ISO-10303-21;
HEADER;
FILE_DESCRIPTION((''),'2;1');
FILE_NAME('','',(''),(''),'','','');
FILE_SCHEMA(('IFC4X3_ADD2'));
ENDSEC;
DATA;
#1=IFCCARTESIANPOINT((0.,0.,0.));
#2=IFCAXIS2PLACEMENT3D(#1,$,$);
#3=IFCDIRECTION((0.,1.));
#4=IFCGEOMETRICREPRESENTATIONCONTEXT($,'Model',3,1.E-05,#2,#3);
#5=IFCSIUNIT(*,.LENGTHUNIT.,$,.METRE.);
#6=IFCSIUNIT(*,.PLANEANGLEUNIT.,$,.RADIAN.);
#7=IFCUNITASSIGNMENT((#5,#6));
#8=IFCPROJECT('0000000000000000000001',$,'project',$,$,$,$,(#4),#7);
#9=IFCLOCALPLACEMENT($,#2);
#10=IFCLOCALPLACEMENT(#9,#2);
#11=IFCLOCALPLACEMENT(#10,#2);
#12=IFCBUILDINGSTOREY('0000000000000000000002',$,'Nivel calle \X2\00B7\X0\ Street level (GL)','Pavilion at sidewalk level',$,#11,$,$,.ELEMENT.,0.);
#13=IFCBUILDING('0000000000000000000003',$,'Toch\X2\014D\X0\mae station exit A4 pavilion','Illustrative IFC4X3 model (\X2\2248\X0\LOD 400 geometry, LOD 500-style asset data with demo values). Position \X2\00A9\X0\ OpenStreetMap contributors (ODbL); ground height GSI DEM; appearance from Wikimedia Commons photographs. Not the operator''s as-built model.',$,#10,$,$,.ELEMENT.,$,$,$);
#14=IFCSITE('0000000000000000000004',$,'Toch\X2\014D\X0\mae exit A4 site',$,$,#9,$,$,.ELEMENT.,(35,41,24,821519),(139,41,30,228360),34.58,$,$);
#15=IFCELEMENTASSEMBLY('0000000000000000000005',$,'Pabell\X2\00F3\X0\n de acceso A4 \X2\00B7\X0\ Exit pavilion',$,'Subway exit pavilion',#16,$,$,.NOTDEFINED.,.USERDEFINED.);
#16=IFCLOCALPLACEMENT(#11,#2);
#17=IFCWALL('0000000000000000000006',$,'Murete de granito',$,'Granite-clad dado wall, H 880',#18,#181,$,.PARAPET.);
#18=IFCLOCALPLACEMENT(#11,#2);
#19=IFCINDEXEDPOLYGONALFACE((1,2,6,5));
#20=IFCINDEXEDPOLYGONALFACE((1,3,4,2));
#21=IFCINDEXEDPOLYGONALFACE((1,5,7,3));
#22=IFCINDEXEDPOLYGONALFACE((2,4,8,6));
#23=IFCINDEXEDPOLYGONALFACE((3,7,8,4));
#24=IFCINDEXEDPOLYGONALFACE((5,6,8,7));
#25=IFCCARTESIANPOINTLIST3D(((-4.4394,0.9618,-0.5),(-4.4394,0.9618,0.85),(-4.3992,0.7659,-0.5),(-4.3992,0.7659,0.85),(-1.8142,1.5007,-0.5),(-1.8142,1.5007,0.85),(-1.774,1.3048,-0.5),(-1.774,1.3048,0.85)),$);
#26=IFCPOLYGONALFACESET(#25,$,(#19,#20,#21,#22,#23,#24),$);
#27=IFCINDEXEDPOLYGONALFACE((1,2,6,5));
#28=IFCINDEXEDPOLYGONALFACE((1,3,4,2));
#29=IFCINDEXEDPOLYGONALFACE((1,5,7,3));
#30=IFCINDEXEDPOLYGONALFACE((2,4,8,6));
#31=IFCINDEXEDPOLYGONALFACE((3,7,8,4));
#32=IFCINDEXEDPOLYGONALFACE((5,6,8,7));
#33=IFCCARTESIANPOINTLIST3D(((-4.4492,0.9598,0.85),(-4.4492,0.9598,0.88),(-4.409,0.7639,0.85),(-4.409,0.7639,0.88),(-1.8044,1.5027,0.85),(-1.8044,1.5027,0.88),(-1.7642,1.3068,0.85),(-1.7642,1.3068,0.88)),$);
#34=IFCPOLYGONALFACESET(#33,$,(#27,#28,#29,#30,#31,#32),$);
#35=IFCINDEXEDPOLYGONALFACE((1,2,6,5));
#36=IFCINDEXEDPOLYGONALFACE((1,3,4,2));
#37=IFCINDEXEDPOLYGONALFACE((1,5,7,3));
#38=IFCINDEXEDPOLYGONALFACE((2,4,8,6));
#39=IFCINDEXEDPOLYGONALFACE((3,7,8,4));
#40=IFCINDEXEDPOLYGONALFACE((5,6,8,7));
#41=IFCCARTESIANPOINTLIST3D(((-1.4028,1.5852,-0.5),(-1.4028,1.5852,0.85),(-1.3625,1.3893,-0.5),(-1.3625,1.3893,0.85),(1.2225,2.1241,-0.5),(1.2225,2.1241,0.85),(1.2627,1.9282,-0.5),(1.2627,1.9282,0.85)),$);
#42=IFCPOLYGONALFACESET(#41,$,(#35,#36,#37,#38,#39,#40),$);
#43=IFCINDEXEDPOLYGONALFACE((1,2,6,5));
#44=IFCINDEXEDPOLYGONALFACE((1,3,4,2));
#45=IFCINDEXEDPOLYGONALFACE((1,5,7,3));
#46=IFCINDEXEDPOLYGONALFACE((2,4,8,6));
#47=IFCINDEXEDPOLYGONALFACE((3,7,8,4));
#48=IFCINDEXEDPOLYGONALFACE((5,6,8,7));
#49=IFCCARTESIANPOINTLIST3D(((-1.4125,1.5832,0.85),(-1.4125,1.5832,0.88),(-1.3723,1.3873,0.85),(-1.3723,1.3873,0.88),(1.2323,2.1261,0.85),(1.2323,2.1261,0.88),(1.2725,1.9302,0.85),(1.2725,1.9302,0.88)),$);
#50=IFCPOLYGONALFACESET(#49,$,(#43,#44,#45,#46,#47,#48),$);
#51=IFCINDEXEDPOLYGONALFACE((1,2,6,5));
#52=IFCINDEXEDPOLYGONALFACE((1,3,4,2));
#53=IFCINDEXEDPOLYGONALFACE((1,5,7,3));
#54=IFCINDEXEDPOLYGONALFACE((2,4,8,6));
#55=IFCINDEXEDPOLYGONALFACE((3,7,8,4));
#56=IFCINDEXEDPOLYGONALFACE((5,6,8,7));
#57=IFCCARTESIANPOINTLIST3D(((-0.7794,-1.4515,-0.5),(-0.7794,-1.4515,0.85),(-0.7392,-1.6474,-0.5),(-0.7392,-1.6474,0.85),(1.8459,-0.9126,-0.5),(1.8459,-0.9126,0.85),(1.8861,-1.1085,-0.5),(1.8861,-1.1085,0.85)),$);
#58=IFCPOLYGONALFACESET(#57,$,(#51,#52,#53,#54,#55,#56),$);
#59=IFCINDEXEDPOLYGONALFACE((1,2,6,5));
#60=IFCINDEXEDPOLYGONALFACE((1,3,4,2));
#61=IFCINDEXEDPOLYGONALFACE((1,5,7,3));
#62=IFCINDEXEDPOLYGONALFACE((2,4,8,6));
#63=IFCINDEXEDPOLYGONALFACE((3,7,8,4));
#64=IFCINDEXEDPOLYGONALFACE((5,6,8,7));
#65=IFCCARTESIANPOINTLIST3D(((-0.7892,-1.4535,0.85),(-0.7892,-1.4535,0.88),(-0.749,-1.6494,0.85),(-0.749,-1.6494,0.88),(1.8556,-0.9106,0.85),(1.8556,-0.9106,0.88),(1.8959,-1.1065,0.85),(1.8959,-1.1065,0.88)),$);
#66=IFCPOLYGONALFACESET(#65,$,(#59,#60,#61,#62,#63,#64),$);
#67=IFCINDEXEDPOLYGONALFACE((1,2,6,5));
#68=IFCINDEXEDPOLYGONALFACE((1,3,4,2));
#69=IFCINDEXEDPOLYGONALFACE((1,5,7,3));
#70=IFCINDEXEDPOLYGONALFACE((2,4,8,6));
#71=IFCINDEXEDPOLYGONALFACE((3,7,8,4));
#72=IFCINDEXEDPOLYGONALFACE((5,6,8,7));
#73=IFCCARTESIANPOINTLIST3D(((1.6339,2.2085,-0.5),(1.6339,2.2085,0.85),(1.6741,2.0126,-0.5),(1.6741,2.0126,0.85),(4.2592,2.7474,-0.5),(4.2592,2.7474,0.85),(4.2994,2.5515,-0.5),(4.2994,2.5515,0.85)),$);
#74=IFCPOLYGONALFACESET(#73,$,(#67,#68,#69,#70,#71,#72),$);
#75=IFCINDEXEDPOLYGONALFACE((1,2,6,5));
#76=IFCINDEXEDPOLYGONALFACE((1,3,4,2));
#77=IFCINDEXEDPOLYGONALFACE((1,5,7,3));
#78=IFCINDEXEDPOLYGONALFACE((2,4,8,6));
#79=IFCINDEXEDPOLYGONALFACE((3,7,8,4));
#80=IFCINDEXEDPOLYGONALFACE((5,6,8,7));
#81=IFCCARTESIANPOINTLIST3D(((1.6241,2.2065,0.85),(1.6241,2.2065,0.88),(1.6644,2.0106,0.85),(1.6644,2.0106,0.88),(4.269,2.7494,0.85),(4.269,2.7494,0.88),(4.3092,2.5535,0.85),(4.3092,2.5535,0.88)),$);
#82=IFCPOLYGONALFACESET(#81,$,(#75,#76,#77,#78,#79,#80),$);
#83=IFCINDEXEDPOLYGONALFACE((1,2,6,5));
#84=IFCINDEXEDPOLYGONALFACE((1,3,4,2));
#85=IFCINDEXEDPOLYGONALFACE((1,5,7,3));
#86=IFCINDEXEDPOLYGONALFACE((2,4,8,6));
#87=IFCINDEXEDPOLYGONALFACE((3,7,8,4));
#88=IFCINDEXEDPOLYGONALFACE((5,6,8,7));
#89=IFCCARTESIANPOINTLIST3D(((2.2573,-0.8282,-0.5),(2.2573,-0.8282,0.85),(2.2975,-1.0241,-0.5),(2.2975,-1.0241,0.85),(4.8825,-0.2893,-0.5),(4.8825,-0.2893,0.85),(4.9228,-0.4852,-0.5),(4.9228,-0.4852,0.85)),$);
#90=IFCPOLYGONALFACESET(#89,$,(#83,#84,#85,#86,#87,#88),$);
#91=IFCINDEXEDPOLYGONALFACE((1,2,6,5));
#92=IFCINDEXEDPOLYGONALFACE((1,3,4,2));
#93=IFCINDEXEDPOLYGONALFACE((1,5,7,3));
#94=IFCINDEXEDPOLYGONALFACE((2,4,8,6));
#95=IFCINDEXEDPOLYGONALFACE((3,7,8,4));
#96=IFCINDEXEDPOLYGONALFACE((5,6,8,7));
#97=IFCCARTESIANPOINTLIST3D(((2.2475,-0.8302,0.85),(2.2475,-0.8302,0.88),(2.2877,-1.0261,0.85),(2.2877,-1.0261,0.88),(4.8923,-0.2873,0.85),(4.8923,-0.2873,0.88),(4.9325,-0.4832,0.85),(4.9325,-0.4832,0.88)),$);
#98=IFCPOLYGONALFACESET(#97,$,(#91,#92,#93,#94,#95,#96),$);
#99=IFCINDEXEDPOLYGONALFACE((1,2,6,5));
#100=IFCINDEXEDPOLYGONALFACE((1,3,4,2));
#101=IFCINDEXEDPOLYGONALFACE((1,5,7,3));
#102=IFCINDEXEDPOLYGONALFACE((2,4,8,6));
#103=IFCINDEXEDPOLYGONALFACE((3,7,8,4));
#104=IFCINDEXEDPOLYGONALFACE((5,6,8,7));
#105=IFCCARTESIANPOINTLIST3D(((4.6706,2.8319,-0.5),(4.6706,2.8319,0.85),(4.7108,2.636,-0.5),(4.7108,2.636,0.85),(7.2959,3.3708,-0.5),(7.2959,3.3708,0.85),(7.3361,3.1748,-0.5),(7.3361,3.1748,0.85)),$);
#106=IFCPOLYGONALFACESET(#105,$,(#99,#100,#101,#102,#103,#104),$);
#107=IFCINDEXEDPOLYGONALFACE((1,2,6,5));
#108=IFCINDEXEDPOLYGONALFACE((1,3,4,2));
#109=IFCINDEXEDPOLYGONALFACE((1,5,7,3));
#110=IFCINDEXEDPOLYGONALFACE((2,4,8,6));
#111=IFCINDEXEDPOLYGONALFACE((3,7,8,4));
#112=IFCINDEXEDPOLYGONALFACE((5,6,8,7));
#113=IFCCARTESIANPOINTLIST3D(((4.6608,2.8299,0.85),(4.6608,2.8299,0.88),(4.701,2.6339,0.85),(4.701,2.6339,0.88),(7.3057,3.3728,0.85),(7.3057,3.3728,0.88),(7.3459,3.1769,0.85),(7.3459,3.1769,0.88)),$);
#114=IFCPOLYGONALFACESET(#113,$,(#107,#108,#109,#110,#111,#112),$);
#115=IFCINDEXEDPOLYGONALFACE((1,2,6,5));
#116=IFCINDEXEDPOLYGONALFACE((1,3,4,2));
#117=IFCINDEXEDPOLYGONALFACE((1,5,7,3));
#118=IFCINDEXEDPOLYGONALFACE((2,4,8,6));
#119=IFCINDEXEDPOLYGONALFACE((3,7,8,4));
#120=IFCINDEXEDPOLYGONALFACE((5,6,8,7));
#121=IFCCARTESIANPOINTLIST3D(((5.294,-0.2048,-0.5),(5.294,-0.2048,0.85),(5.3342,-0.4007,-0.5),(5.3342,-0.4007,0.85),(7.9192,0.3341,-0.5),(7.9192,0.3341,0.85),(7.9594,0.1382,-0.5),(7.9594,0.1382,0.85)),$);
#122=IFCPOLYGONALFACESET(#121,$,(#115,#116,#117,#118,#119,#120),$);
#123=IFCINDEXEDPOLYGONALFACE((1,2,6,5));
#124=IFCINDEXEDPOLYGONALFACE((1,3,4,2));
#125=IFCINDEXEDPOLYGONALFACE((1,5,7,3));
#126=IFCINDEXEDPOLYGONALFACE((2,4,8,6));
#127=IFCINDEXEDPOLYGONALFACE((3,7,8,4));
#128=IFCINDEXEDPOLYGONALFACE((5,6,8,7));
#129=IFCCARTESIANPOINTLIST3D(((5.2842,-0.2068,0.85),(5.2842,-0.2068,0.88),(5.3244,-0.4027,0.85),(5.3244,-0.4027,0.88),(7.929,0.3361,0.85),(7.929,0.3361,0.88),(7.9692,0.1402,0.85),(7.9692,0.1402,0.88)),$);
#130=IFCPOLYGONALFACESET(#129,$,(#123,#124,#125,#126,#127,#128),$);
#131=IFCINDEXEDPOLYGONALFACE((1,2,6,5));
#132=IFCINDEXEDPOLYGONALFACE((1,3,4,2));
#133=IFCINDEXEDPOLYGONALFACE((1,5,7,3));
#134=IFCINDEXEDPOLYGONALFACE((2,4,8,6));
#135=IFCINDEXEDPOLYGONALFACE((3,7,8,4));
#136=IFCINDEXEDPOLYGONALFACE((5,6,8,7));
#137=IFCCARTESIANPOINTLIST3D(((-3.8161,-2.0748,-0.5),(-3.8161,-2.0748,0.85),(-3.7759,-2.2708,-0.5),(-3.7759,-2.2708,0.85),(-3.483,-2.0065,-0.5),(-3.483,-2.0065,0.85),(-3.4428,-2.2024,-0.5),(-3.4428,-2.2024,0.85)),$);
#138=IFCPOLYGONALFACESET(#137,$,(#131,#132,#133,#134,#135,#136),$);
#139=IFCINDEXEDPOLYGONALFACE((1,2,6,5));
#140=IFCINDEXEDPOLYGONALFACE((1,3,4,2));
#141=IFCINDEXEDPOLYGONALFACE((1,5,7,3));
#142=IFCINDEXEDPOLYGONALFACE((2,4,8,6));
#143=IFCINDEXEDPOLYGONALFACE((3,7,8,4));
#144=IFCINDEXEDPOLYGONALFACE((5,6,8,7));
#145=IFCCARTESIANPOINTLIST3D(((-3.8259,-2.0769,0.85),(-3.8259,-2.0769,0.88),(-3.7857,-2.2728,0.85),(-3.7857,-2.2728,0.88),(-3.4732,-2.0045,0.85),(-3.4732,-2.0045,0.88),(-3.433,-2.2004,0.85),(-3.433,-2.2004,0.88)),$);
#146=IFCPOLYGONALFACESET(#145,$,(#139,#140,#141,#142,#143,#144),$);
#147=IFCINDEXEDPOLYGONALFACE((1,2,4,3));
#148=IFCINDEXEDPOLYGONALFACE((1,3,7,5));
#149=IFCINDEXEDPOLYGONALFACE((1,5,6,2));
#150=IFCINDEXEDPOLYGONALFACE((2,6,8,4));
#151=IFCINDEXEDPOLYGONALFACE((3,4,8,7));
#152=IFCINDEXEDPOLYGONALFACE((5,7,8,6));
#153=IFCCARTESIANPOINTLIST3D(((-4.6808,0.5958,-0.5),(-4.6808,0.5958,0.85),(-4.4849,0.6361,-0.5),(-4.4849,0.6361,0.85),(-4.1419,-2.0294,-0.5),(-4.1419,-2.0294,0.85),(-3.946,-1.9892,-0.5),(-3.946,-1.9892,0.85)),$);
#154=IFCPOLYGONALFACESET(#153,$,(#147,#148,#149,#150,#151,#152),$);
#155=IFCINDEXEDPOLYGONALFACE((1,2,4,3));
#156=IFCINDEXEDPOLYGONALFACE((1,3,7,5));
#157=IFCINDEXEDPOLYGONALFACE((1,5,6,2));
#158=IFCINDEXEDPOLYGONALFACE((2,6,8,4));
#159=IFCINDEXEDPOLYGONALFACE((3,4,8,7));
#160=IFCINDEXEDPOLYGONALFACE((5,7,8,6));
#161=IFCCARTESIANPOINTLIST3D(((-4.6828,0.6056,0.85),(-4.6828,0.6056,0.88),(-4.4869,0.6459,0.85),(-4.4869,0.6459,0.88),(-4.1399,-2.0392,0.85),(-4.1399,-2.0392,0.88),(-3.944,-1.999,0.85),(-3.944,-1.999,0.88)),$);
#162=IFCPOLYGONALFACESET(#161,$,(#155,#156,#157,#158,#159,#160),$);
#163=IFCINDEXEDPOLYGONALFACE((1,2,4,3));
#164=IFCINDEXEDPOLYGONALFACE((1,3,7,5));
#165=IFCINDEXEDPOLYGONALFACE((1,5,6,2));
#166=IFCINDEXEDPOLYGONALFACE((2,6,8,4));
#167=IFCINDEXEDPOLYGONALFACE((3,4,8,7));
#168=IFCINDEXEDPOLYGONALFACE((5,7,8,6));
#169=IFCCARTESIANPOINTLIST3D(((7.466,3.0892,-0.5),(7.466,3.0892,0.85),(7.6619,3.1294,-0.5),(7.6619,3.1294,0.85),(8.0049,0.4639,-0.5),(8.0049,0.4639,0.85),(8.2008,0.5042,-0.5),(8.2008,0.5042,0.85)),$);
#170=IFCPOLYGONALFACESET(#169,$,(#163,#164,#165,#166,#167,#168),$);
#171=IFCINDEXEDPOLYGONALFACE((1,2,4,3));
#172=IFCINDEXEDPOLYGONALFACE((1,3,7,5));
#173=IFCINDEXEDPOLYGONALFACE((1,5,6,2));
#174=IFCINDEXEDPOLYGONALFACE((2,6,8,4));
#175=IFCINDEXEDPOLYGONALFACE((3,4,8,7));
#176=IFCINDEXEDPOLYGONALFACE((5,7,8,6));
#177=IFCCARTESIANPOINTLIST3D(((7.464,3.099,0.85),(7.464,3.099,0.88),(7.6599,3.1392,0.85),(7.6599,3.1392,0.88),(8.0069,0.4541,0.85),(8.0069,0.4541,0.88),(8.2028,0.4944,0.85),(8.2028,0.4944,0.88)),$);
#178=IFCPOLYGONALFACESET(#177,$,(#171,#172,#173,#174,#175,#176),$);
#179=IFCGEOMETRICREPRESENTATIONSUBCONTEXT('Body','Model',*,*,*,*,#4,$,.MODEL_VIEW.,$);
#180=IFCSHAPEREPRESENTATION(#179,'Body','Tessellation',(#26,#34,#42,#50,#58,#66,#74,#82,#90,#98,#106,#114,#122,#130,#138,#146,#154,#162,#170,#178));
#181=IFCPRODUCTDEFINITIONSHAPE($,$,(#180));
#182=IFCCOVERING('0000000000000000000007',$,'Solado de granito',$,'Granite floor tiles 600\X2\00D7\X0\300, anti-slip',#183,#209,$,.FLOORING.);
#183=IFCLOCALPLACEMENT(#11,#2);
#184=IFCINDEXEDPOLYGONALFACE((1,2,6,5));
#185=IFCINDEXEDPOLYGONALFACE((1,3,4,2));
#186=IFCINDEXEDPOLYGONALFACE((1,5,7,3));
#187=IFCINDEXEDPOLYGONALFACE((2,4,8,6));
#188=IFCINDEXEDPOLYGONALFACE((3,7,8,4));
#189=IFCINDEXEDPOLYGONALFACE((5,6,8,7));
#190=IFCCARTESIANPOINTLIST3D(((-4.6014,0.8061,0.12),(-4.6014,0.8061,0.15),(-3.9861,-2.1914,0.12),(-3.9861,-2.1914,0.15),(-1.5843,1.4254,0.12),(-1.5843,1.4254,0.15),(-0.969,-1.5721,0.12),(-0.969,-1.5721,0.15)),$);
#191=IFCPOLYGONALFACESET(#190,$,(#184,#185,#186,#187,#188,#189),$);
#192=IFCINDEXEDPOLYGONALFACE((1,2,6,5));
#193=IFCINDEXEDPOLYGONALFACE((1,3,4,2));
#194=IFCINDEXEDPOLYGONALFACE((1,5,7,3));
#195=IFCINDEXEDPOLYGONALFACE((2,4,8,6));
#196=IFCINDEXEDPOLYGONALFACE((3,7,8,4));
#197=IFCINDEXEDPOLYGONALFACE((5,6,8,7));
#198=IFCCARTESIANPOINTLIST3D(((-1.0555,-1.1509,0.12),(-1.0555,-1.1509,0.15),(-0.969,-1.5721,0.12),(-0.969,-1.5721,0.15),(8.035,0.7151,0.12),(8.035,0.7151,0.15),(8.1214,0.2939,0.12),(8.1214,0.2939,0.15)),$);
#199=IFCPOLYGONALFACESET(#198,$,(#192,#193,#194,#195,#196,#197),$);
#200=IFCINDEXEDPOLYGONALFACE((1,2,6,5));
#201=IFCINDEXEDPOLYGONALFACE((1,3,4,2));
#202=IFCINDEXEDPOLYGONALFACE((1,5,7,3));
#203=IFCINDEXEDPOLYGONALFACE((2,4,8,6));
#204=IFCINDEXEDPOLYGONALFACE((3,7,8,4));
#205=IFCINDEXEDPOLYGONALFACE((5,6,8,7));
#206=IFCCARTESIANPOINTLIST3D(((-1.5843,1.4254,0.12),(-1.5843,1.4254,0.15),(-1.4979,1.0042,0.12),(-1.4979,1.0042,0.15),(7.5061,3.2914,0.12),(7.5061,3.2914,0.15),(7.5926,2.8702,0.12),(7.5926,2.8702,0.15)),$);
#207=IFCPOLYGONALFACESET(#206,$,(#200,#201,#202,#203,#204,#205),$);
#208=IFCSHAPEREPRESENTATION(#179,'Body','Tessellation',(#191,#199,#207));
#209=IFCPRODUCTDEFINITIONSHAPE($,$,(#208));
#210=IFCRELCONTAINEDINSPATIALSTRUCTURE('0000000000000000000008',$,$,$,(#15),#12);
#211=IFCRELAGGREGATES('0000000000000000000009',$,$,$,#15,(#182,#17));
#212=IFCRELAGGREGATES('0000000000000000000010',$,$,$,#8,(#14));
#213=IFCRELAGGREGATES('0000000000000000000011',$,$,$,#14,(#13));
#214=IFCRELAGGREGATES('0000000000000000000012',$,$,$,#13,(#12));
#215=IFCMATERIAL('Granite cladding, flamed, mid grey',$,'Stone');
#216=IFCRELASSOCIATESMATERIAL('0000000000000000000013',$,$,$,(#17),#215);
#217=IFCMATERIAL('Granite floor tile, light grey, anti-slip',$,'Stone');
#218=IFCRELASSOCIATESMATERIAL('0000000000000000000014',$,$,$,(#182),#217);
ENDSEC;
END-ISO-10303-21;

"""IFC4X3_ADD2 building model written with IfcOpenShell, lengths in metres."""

from ifc_helpers import new_model, si_unit, direction, frame, frame_2d, origin, place, context, subcontext, project, spatial, rectangle, extrude, material, element, aggregate, save


model = new_model("IFC4X3_ADD2")

# Units and contexts
model_context = context("Model", 3, precision=1e-05, world=origin(), true_north=direction((0.0, 1.0)))
body_context = subcontext(model_context, "Body", "Model", "MODEL_VIEW")
ifc_project = project(units=[si_unit("LENGTHUNIT", "METRE"), si_unit("PLANEANGLEUNIT", "RADIAN")], contexts=[model_context])

# Site, building, storey
site_placement = place(None, origin())
site = spatial("IfcSite", under=ifc_project, at=site_placement, Name="Tochōmae exit A4 site", CompositionType="ELEMENT", RefLatitude=(35, 41, 24, 821519), RefLongitude=(139, 41, 30, 228360), RefElevation=34.58)
building_placement = place(site_placement, origin())
building = spatial("IfcBuilding", under=site, at=building_placement, Name="Tochōmae station exit A4 pavilion", Description="Illustrative IFC4X3 model (≈LOD 400 geometry, LOD 500-style asset data with demo values). Position © OpenStreetMap contributors (ODbL); ground height GSI DEM; appearance from Wikimedia Commons photographs. Not the operator's as-built model.", CompositionType="ELEMENT")
storey_placement = place(building_placement, origin())
storey = spatial("IfcBuildingStorey", under=building, at=storey_placement, Name="Nivel calle · Street level (GL)", Description="Pavilion at sidewalk level", CompositionType="ELEMENT", Elevation=0.0)

# Element assembly, wall, covering
assembly_1_placement = place(building_placement, origin())
assembly_1 = element("IfcElementAssembly", 1, at=assembly_1_placement, inside=storey, Name="Pabellón de acceso A4 · Exit pavilion", ObjectType="Subway exit pavilion", AssemblyPlace="NOTDEFINED", PredefinedType="USERDEFINED")
ifc_material_1 = material(Name="Granite cladding, flamed, mid grey", Category="Stone")
wall_placement = place(building_placement, origin())
wall = element("IfcWall", 2, at=wall_placement, material=ifc_material_1, Name="Murete de granito", ObjectType="Granite-clad dado wall, H 880", PredefinedType="PARAPET", context=body_context, shape_type="SweptSolid", body=[
    extrude(rectangle(XDim=2.68, YDim=0.2, at=frame_2d((0.0, 0.0), x_axis=(0.979575, 0.201078))), frame((-3.1067, 1.1333, -0.5)), (0.0, 0.0, 1.0), 1.35),
    extrude(rectangle(XDim=2.7, YDim=0.2, at=frame_2d((0.0, 0.0), x_axis=(0.979575, 0.201078))), frame((-3.1067, 1.1333, 0.85)), (0.0, 0.0, 1.0), 0.03),
    extrude(rectangle(XDim=2.68, YDim=0.2, at=frame_2d((0.0, 0.0), x_axis=(0.979575, 0.201078))), frame((-0.07, 1.7567, -0.5)), (0.0, 0.0, 1.0), 1.35),
    extrude(rectangle(XDim=2.7, YDim=0.2, at=frame_2d((0.0, 0.0), x_axis=(0.979575, 0.201078))), frame((-0.07, 1.7567, 0.85)), (0.0, 0.0, 1.0), 0.03),
    extrude(rectangle(XDim=2.68, YDim=0.2, at=frame_2d((0.0, 0.0), x_axis=(0.979575, 0.201078))), frame((0.5533, -1.28, -0.5)), (0.0, 0.0, 1.0), 1.35),
    extrude(rectangle(XDim=2.7, YDim=0.2, at=frame_2d((0.0, 0.0), x_axis=(0.979575, 0.201078))), frame((0.5533, -1.28, 0.85)), (0.0, 0.0, 1.0), 0.03),
    extrude(rectangle(XDim=2.68, YDim=0.2, at=frame_2d((0.0, 0.0), x_axis=(0.979575, 0.201078))), frame((2.9667, 2.38, -0.5)), (0.0, 0.0, 1.0), 1.35),
    extrude(rectangle(XDim=2.7, YDim=0.2, at=frame_2d((0.0, 0.0), x_axis=(0.979575, 0.201078))), frame((2.9667, 2.38, 0.85)), (0.0, 0.0, 1.0), 0.03),
    extrude(rectangle(XDim=2.68, YDim=0.2, at=frame_2d((0.0, 0.0), x_axis=(0.979575, 0.201078))), frame((3.59, -0.6567, -0.5)), (0.0, 0.0, 1.0), 1.35),
    extrude(rectangle(XDim=2.7, YDim=0.2, at=frame_2d((0.0, 0.0), x_axis=(0.979575, 0.201078))), frame((3.59, -0.6567, 0.85)), (0.0, 0.0, 1.0), 0.03),
    extrude(rectangle(XDim=2.68, YDim=0.2, at=frame_2d((0.0, 0.0), x_axis=(0.979575, 0.201078))), frame((6.0034, 3.0034, -0.5)), (0.0, 0.0, 1.0), 1.35),
    extrude(rectangle(XDim=2.7, YDim=0.2, at=frame_2d((0.0, 0.0), x_axis=(0.979575, 0.201078))), frame((6.0034, 3.0034, 0.85)), (0.0, 0.0, 1.0), 0.03),
    extrude(rectangle(XDim=2.68, YDim=0.2, at=frame_2d((0.0, 0.0), x_axis=(0.979575, 0.201078))), frame((6.6267, -0.0333, -0.5)), (0.0, 0.0, 1.0), 1.35),
    extrude(rectangle(XDim=2.7, YDim=0.2, at=frame_2d((0.0, 0.0), x_axis=(0.979575, 0.201078))), frame((6.6267, -0.0333, 0.85)), (0.0, 0.0, 1.0), 0.03),
    extrude(rectangle(XDim=0.34, YDim=0.2, at=frame_2d((0.0, 0.0), x_axis=(0.979575, 0.201078))), frame((-3.6295, -2.1386, -0.5)), (0.0, 0.0, 1.0), 1.35),
    extrude(rectangle(XDim=0.36, YDim=0.2, at=frame_2d((0.0, 0.0), x_axis=(0.979575, 0.201078))), frame((-3.6295, -2.1386, 0.85)), (0.0, 0.0, 1.0), 0.03),
    extrude(rectangle(XDim=0.2, YDim=2.68, at=frame_2d((0.0, 0.0), x_axis=(0.979575, 0.201078))), frame((-4.3134, -0.6967, -0.5)), (0.0, 0.0, 1.0), 1.35),
    extrude(rectangle(XDim=0.2, YDim=2.7, at=frame_2d((0.0, 0.0), x_axis=(0.979575, 0.201078))), frame((-4.3134, -0.6967, 0.85)), (0.0, 0.0, 1.0), 0.03),
    extrude(rectangle(XDim=0.2, YDim=2.68, at=frame_2d((0.0, 0.0), x_axis=(0.979575, 0.201078))), frame((7.8334, 1.7967, -0.5)), (0.0, 0.0, 1.0), 1.35),
    extrude(rectangle(XDim=0.2, YDim=2.7, at=frame_2d((0.0, 0.0), x_axis=(0.979575, 0.201078))), frame((7.8334, 1.7967, 0.85)), (0.0, 0.0, 1.0), 0.03),
])
ifc_material_2 = material(Name="Granite floor tile, light grey, anti-slip", Category="Stone")
covering_1_placement = place(building_placement, origin())
covering_1 = element("IfcCovering", 3, at=covering_1_placement, material=ifc_material_2, Name="Solado de granito", ObjectType="Granite floor tiles 600×300, anti-slip", PredefinedType="FLOORING", context=body_context, shape_type="SweptSolid", body=[
    extrude(rectangle(XDim=3.08, YDim=3.06, at=frame_2d((0.0, 0.0), x_axis=(0.979575, 0.201078))), frame((-2.7852, -0.383, 0.12)), (0.0, 0.0, 1.0), 0.03),
    extrude(rectangle(XDim=9.28, YDim=0.43, at=frame_2d((0.0, 0.0), x_axis=(0.979575, 0.201078))), frame((3.533, -0.4285, 0.12)), (0.0, 0.0, 1.0), 0.03),
    extrude(rectangle(XDim=9.28, YDim=0.43, at=frame_2d((0.0, 0.0), x_axis=(0.979575, 0.201078))), frame((3.0041, 2.1478, 0.12)), (0.0, 0.0, 1.0), 0.03),
])
aggregate(assembly_1, [covering_1, wall])

save(model, "model.ifc")
